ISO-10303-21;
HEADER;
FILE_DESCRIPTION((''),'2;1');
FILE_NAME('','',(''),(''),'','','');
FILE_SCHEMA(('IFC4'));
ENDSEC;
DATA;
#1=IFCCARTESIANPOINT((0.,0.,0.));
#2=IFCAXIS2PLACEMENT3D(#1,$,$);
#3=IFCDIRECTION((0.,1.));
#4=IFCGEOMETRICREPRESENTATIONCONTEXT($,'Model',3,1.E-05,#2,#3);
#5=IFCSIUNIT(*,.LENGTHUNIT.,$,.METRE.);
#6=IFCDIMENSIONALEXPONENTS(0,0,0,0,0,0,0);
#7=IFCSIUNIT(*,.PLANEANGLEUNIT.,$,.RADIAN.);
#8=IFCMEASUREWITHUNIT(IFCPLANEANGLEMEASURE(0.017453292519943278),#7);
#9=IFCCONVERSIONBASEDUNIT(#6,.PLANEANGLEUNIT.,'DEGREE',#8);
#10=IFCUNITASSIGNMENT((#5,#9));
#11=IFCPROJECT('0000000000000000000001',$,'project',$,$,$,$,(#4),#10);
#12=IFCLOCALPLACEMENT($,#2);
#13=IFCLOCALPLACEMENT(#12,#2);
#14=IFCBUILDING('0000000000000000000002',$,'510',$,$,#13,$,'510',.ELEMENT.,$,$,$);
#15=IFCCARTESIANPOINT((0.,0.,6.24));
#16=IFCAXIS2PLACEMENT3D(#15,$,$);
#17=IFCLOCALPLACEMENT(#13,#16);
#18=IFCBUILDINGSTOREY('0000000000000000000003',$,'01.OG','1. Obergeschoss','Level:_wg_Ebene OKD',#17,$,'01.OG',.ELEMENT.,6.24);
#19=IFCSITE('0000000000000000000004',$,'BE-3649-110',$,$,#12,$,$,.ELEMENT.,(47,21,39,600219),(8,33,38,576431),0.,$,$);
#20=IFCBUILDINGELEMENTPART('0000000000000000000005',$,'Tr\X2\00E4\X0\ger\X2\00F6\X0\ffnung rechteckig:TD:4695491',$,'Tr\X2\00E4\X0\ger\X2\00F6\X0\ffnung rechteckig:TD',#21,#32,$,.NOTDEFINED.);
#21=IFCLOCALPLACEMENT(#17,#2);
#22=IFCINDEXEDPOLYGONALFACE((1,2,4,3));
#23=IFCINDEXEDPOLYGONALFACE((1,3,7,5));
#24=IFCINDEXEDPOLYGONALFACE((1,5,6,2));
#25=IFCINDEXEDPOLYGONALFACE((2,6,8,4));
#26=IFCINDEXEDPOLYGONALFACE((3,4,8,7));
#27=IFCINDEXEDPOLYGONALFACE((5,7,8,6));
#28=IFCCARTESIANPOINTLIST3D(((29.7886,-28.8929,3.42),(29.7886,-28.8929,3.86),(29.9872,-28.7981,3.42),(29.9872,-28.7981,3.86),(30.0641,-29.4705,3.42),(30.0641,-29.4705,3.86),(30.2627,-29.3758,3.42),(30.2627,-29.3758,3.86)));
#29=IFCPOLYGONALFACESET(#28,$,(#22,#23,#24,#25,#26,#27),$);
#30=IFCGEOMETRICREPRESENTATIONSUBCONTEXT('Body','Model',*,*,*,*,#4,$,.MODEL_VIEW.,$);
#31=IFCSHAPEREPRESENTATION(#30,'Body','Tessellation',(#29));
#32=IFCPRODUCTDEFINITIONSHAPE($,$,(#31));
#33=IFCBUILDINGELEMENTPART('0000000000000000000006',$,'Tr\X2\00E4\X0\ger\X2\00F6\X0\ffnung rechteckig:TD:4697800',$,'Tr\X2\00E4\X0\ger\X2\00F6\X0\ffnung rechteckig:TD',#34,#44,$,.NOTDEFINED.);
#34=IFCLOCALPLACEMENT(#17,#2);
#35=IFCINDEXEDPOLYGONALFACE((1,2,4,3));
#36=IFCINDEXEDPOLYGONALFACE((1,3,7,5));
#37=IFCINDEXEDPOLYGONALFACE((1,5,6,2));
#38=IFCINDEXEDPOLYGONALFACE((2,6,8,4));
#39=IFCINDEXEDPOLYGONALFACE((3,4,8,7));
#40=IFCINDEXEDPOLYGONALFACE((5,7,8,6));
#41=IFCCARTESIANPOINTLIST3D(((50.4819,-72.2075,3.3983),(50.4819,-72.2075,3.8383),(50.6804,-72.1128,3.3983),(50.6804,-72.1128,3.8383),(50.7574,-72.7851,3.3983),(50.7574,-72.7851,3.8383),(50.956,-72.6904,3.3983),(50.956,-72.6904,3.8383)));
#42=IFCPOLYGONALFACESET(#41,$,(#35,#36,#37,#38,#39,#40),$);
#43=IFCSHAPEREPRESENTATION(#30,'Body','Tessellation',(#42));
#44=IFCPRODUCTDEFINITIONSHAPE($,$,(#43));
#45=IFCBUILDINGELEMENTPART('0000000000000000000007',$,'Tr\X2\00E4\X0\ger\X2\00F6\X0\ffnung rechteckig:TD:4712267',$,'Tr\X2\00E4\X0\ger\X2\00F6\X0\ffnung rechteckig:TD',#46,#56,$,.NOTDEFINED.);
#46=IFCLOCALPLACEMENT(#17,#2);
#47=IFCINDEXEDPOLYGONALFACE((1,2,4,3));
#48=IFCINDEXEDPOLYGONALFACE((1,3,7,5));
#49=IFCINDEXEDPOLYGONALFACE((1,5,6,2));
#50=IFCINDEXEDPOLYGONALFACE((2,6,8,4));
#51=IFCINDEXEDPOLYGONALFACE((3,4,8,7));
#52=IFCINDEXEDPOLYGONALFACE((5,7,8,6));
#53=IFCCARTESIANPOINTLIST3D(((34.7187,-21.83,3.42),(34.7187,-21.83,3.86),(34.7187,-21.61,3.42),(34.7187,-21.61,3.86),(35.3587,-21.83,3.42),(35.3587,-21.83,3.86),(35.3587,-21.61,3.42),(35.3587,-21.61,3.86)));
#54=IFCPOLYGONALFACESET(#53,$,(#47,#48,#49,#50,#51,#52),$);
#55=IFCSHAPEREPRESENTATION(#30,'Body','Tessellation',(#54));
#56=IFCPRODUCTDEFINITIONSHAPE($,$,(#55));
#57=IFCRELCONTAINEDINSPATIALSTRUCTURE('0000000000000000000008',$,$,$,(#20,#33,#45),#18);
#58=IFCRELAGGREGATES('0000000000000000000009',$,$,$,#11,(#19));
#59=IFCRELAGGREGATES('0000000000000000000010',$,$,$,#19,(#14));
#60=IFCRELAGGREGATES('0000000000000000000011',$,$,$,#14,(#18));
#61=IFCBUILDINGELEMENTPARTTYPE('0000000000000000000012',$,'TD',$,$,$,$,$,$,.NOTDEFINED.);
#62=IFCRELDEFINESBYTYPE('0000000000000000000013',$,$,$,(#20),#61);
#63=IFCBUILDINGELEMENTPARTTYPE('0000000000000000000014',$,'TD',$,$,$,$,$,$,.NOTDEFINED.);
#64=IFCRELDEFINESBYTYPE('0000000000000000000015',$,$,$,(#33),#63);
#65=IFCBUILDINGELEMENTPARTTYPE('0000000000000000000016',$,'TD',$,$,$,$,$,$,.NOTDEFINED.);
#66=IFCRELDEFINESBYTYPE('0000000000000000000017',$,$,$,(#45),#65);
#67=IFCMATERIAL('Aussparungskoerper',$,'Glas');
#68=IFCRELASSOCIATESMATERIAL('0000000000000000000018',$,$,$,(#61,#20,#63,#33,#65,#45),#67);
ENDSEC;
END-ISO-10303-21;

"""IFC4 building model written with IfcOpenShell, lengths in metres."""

from ifc_helpers import new_model, entity, si_unit, converted_unit, direction, frame, origin, place, context, subcontext, project, spatial, indexed_curve, outline, extrude, source, transform, mapped, material, type_object, type_shapes, element, save


model = new_model("IFC4")

# Units and contexts
model_context = context("Model", 3, precision=1e-05, world=origin(), true_north=direction((0.0, 1.0)))
body_context = subcontext(model_context, "Body", "Model", "MODEL_VIEW")
ifc_project = project(units=[si_unit("LENGTHUNIT", "METRE"), converted_unit("PLANEANGLEUNIT", "DEGREE", entity("IfcPlaneAngleMeasure", 0.017453292519943278), si_unit("PLANEANGLEUNIT", "RADIAN"), dimensions=[0, 0, 0, 0, 0, 0, 0])], contexts=[model_context])

# Site, building, storey
site_placement = place(None, origin())
site = spatial("IfcSite", under=ifc_project, at=site_placement, Name="BE-3649-110", CompositionType="ELEMENT", RefLatitude=(47, 21, 39, 600219), RefLongitude=(8, 33, 38, 576431), RefElevation=0.0)
building_placement = place(site_placement, origin())
building = spatial("IfcBuilding", under=site, at=building_placement, Name="510", LongName="510", CompositionType="ELEMENT")
storey_placement = place(building_placement, frame((0.0, 0.0, 6.24)))
storey = spatial("IfcBuildingStorey", under=building, at=storey_placement, Name="01.OG", Description="1. Obergeschoss", ObjectType="Level:_wg_Ebene OKD", LongName="01.OG", CompositionType="ELEMENT", Elevation=6.24)

# Building element parts
ifc_material_1 = material(Name="Aussparungskoerper", Category="Glas")
building_element_part_type_1 = type_object("IfcBuildingElementPartType", Name="TD", PredefinedType="NOTDEFINED", material=ifc_material_1)
shared_shape_1 = source(origin(), body_context, "Body", "SweptSolid", [
    extrude(outline(indexed_curve([(-0.11, -0.32), (0.11, -0.32), (0.11, 0.32), (-0.11, 0.32), (-0.11, -0.32)], self_intersect=False)), frame((30.0256, -29.1343, -0.44), z_axis=(0.0, 0.0, 1.0), x_axis=(-0.902585, -0.430511, 0.0)), (0.0, 0.0, 1.0), 0.44),
])
type_shapes(building_element_part_type_1, [shared_shape_1])
building_element_part_1_placement = place(storey_placement, frame((0.0, 0.0, 3.86)))
element("IfcBuildingElementPart", 1, at=building_element_part_1_placement, inside=storey, type_object=building_element_part_type_1, material=ifc_material_1, Name="Trägeröffnung rechteckig:TD:4695491", ObjectType="Trägeröffnung rechteckig:TD", PredefinedType="NOTDEFINED", context=body_context, shape_type="MappedRepresentation", body=[
    mapped(shared_shape_1, transform((0.0, 0.0, 0.0), scale=1.0)),
])
building_element_part_type_2 = type_object("IfcBuildingElementPartType", Name="TD", PredefinedType="NOTDEFINED", material=ifc_material_1)
shared_shape_2 = source(origin(), body_context, "Body", "SweptSolid", [
    extrude(outline(indexed_curve([(-0.11, -0.32), (0.11, -0.32), (0.11, 0.32), (-0.11, 0.32), (-0.11, -0.32)], self_intersect=False)), frame((50.7189, -72.449, -0.44), z_axis=(0.0, 0.0, 1.0), x_axis=(0.902586, 0.43051, 0.0)), (0.0, 0.0, 1.0), 0.44),
])
type_shapes(building_element_part_type_2, [shared_shape_2])
building_element_part_2_placement = place(storey_placement, frame((0.0, 0.0, 3.8383)))
element("IfcBuildingElementPart", 2, at=building_element_part_2_placement, inside=storey, type_object=building_element_part_type_2, material=ifc_material_1, Name="Trägeröffnung rechteckig:TD:4697800", ObjectType="Trägeröffnung rechteckig:TD", PredefinedType="NOTDEFINED", context=body_context, shape_type="MappedRepresentation", body=[
    mapped(shared_shape_2, transform((0.0, 0.0, 0.0), scale=1.0)),
])
building_element_part_type_3 = type_object("IfcBuildingElementPartType", Name="TD", PredefinedType="NOTDEFINED", material=ifc_material_1)
shared_shape_3 = source(origin(), body_context, "Body", "SweptSolid", [
    extrude(outline(indexed_curve([(-0.11, -0.32), (0.11, -0.32), (0.11, 0.32), (-0.11, 0.32), (-0.11, -0.32)], self_intersect=False)), frame((35.0387, -21.72, -0.44), z_axis=(0.0, 0.0, 1.0), x_axis=(0.0, 1.0, 0.0)), (0.0, 0.0, 1.0), 0.44),
])
type_shapes(building_element_part_type_3, [shared_shape_3])
building_element_part_3_placement = place(storey_placement, frame((0.0, 0.0, 3.86)))
element("IfcBuildingElementPart", 3, at=building_element_part_3_placement, inside=storey, type_object=building_element_part_type_3, material=ifc_material_1, Name="Trägeröffnung rechteckig:TD:4712267", ObjectType="Trägeröffnung rechteckig:TD", PredefinedType="NOTDEFINED", context=body_context, shape_type="MappedRepresentation", body=[
    mapped(shared_shape_3, transform((0.0, 0.0, 0.0), scale=1.0)),
])

save(model, "model.ifc")
